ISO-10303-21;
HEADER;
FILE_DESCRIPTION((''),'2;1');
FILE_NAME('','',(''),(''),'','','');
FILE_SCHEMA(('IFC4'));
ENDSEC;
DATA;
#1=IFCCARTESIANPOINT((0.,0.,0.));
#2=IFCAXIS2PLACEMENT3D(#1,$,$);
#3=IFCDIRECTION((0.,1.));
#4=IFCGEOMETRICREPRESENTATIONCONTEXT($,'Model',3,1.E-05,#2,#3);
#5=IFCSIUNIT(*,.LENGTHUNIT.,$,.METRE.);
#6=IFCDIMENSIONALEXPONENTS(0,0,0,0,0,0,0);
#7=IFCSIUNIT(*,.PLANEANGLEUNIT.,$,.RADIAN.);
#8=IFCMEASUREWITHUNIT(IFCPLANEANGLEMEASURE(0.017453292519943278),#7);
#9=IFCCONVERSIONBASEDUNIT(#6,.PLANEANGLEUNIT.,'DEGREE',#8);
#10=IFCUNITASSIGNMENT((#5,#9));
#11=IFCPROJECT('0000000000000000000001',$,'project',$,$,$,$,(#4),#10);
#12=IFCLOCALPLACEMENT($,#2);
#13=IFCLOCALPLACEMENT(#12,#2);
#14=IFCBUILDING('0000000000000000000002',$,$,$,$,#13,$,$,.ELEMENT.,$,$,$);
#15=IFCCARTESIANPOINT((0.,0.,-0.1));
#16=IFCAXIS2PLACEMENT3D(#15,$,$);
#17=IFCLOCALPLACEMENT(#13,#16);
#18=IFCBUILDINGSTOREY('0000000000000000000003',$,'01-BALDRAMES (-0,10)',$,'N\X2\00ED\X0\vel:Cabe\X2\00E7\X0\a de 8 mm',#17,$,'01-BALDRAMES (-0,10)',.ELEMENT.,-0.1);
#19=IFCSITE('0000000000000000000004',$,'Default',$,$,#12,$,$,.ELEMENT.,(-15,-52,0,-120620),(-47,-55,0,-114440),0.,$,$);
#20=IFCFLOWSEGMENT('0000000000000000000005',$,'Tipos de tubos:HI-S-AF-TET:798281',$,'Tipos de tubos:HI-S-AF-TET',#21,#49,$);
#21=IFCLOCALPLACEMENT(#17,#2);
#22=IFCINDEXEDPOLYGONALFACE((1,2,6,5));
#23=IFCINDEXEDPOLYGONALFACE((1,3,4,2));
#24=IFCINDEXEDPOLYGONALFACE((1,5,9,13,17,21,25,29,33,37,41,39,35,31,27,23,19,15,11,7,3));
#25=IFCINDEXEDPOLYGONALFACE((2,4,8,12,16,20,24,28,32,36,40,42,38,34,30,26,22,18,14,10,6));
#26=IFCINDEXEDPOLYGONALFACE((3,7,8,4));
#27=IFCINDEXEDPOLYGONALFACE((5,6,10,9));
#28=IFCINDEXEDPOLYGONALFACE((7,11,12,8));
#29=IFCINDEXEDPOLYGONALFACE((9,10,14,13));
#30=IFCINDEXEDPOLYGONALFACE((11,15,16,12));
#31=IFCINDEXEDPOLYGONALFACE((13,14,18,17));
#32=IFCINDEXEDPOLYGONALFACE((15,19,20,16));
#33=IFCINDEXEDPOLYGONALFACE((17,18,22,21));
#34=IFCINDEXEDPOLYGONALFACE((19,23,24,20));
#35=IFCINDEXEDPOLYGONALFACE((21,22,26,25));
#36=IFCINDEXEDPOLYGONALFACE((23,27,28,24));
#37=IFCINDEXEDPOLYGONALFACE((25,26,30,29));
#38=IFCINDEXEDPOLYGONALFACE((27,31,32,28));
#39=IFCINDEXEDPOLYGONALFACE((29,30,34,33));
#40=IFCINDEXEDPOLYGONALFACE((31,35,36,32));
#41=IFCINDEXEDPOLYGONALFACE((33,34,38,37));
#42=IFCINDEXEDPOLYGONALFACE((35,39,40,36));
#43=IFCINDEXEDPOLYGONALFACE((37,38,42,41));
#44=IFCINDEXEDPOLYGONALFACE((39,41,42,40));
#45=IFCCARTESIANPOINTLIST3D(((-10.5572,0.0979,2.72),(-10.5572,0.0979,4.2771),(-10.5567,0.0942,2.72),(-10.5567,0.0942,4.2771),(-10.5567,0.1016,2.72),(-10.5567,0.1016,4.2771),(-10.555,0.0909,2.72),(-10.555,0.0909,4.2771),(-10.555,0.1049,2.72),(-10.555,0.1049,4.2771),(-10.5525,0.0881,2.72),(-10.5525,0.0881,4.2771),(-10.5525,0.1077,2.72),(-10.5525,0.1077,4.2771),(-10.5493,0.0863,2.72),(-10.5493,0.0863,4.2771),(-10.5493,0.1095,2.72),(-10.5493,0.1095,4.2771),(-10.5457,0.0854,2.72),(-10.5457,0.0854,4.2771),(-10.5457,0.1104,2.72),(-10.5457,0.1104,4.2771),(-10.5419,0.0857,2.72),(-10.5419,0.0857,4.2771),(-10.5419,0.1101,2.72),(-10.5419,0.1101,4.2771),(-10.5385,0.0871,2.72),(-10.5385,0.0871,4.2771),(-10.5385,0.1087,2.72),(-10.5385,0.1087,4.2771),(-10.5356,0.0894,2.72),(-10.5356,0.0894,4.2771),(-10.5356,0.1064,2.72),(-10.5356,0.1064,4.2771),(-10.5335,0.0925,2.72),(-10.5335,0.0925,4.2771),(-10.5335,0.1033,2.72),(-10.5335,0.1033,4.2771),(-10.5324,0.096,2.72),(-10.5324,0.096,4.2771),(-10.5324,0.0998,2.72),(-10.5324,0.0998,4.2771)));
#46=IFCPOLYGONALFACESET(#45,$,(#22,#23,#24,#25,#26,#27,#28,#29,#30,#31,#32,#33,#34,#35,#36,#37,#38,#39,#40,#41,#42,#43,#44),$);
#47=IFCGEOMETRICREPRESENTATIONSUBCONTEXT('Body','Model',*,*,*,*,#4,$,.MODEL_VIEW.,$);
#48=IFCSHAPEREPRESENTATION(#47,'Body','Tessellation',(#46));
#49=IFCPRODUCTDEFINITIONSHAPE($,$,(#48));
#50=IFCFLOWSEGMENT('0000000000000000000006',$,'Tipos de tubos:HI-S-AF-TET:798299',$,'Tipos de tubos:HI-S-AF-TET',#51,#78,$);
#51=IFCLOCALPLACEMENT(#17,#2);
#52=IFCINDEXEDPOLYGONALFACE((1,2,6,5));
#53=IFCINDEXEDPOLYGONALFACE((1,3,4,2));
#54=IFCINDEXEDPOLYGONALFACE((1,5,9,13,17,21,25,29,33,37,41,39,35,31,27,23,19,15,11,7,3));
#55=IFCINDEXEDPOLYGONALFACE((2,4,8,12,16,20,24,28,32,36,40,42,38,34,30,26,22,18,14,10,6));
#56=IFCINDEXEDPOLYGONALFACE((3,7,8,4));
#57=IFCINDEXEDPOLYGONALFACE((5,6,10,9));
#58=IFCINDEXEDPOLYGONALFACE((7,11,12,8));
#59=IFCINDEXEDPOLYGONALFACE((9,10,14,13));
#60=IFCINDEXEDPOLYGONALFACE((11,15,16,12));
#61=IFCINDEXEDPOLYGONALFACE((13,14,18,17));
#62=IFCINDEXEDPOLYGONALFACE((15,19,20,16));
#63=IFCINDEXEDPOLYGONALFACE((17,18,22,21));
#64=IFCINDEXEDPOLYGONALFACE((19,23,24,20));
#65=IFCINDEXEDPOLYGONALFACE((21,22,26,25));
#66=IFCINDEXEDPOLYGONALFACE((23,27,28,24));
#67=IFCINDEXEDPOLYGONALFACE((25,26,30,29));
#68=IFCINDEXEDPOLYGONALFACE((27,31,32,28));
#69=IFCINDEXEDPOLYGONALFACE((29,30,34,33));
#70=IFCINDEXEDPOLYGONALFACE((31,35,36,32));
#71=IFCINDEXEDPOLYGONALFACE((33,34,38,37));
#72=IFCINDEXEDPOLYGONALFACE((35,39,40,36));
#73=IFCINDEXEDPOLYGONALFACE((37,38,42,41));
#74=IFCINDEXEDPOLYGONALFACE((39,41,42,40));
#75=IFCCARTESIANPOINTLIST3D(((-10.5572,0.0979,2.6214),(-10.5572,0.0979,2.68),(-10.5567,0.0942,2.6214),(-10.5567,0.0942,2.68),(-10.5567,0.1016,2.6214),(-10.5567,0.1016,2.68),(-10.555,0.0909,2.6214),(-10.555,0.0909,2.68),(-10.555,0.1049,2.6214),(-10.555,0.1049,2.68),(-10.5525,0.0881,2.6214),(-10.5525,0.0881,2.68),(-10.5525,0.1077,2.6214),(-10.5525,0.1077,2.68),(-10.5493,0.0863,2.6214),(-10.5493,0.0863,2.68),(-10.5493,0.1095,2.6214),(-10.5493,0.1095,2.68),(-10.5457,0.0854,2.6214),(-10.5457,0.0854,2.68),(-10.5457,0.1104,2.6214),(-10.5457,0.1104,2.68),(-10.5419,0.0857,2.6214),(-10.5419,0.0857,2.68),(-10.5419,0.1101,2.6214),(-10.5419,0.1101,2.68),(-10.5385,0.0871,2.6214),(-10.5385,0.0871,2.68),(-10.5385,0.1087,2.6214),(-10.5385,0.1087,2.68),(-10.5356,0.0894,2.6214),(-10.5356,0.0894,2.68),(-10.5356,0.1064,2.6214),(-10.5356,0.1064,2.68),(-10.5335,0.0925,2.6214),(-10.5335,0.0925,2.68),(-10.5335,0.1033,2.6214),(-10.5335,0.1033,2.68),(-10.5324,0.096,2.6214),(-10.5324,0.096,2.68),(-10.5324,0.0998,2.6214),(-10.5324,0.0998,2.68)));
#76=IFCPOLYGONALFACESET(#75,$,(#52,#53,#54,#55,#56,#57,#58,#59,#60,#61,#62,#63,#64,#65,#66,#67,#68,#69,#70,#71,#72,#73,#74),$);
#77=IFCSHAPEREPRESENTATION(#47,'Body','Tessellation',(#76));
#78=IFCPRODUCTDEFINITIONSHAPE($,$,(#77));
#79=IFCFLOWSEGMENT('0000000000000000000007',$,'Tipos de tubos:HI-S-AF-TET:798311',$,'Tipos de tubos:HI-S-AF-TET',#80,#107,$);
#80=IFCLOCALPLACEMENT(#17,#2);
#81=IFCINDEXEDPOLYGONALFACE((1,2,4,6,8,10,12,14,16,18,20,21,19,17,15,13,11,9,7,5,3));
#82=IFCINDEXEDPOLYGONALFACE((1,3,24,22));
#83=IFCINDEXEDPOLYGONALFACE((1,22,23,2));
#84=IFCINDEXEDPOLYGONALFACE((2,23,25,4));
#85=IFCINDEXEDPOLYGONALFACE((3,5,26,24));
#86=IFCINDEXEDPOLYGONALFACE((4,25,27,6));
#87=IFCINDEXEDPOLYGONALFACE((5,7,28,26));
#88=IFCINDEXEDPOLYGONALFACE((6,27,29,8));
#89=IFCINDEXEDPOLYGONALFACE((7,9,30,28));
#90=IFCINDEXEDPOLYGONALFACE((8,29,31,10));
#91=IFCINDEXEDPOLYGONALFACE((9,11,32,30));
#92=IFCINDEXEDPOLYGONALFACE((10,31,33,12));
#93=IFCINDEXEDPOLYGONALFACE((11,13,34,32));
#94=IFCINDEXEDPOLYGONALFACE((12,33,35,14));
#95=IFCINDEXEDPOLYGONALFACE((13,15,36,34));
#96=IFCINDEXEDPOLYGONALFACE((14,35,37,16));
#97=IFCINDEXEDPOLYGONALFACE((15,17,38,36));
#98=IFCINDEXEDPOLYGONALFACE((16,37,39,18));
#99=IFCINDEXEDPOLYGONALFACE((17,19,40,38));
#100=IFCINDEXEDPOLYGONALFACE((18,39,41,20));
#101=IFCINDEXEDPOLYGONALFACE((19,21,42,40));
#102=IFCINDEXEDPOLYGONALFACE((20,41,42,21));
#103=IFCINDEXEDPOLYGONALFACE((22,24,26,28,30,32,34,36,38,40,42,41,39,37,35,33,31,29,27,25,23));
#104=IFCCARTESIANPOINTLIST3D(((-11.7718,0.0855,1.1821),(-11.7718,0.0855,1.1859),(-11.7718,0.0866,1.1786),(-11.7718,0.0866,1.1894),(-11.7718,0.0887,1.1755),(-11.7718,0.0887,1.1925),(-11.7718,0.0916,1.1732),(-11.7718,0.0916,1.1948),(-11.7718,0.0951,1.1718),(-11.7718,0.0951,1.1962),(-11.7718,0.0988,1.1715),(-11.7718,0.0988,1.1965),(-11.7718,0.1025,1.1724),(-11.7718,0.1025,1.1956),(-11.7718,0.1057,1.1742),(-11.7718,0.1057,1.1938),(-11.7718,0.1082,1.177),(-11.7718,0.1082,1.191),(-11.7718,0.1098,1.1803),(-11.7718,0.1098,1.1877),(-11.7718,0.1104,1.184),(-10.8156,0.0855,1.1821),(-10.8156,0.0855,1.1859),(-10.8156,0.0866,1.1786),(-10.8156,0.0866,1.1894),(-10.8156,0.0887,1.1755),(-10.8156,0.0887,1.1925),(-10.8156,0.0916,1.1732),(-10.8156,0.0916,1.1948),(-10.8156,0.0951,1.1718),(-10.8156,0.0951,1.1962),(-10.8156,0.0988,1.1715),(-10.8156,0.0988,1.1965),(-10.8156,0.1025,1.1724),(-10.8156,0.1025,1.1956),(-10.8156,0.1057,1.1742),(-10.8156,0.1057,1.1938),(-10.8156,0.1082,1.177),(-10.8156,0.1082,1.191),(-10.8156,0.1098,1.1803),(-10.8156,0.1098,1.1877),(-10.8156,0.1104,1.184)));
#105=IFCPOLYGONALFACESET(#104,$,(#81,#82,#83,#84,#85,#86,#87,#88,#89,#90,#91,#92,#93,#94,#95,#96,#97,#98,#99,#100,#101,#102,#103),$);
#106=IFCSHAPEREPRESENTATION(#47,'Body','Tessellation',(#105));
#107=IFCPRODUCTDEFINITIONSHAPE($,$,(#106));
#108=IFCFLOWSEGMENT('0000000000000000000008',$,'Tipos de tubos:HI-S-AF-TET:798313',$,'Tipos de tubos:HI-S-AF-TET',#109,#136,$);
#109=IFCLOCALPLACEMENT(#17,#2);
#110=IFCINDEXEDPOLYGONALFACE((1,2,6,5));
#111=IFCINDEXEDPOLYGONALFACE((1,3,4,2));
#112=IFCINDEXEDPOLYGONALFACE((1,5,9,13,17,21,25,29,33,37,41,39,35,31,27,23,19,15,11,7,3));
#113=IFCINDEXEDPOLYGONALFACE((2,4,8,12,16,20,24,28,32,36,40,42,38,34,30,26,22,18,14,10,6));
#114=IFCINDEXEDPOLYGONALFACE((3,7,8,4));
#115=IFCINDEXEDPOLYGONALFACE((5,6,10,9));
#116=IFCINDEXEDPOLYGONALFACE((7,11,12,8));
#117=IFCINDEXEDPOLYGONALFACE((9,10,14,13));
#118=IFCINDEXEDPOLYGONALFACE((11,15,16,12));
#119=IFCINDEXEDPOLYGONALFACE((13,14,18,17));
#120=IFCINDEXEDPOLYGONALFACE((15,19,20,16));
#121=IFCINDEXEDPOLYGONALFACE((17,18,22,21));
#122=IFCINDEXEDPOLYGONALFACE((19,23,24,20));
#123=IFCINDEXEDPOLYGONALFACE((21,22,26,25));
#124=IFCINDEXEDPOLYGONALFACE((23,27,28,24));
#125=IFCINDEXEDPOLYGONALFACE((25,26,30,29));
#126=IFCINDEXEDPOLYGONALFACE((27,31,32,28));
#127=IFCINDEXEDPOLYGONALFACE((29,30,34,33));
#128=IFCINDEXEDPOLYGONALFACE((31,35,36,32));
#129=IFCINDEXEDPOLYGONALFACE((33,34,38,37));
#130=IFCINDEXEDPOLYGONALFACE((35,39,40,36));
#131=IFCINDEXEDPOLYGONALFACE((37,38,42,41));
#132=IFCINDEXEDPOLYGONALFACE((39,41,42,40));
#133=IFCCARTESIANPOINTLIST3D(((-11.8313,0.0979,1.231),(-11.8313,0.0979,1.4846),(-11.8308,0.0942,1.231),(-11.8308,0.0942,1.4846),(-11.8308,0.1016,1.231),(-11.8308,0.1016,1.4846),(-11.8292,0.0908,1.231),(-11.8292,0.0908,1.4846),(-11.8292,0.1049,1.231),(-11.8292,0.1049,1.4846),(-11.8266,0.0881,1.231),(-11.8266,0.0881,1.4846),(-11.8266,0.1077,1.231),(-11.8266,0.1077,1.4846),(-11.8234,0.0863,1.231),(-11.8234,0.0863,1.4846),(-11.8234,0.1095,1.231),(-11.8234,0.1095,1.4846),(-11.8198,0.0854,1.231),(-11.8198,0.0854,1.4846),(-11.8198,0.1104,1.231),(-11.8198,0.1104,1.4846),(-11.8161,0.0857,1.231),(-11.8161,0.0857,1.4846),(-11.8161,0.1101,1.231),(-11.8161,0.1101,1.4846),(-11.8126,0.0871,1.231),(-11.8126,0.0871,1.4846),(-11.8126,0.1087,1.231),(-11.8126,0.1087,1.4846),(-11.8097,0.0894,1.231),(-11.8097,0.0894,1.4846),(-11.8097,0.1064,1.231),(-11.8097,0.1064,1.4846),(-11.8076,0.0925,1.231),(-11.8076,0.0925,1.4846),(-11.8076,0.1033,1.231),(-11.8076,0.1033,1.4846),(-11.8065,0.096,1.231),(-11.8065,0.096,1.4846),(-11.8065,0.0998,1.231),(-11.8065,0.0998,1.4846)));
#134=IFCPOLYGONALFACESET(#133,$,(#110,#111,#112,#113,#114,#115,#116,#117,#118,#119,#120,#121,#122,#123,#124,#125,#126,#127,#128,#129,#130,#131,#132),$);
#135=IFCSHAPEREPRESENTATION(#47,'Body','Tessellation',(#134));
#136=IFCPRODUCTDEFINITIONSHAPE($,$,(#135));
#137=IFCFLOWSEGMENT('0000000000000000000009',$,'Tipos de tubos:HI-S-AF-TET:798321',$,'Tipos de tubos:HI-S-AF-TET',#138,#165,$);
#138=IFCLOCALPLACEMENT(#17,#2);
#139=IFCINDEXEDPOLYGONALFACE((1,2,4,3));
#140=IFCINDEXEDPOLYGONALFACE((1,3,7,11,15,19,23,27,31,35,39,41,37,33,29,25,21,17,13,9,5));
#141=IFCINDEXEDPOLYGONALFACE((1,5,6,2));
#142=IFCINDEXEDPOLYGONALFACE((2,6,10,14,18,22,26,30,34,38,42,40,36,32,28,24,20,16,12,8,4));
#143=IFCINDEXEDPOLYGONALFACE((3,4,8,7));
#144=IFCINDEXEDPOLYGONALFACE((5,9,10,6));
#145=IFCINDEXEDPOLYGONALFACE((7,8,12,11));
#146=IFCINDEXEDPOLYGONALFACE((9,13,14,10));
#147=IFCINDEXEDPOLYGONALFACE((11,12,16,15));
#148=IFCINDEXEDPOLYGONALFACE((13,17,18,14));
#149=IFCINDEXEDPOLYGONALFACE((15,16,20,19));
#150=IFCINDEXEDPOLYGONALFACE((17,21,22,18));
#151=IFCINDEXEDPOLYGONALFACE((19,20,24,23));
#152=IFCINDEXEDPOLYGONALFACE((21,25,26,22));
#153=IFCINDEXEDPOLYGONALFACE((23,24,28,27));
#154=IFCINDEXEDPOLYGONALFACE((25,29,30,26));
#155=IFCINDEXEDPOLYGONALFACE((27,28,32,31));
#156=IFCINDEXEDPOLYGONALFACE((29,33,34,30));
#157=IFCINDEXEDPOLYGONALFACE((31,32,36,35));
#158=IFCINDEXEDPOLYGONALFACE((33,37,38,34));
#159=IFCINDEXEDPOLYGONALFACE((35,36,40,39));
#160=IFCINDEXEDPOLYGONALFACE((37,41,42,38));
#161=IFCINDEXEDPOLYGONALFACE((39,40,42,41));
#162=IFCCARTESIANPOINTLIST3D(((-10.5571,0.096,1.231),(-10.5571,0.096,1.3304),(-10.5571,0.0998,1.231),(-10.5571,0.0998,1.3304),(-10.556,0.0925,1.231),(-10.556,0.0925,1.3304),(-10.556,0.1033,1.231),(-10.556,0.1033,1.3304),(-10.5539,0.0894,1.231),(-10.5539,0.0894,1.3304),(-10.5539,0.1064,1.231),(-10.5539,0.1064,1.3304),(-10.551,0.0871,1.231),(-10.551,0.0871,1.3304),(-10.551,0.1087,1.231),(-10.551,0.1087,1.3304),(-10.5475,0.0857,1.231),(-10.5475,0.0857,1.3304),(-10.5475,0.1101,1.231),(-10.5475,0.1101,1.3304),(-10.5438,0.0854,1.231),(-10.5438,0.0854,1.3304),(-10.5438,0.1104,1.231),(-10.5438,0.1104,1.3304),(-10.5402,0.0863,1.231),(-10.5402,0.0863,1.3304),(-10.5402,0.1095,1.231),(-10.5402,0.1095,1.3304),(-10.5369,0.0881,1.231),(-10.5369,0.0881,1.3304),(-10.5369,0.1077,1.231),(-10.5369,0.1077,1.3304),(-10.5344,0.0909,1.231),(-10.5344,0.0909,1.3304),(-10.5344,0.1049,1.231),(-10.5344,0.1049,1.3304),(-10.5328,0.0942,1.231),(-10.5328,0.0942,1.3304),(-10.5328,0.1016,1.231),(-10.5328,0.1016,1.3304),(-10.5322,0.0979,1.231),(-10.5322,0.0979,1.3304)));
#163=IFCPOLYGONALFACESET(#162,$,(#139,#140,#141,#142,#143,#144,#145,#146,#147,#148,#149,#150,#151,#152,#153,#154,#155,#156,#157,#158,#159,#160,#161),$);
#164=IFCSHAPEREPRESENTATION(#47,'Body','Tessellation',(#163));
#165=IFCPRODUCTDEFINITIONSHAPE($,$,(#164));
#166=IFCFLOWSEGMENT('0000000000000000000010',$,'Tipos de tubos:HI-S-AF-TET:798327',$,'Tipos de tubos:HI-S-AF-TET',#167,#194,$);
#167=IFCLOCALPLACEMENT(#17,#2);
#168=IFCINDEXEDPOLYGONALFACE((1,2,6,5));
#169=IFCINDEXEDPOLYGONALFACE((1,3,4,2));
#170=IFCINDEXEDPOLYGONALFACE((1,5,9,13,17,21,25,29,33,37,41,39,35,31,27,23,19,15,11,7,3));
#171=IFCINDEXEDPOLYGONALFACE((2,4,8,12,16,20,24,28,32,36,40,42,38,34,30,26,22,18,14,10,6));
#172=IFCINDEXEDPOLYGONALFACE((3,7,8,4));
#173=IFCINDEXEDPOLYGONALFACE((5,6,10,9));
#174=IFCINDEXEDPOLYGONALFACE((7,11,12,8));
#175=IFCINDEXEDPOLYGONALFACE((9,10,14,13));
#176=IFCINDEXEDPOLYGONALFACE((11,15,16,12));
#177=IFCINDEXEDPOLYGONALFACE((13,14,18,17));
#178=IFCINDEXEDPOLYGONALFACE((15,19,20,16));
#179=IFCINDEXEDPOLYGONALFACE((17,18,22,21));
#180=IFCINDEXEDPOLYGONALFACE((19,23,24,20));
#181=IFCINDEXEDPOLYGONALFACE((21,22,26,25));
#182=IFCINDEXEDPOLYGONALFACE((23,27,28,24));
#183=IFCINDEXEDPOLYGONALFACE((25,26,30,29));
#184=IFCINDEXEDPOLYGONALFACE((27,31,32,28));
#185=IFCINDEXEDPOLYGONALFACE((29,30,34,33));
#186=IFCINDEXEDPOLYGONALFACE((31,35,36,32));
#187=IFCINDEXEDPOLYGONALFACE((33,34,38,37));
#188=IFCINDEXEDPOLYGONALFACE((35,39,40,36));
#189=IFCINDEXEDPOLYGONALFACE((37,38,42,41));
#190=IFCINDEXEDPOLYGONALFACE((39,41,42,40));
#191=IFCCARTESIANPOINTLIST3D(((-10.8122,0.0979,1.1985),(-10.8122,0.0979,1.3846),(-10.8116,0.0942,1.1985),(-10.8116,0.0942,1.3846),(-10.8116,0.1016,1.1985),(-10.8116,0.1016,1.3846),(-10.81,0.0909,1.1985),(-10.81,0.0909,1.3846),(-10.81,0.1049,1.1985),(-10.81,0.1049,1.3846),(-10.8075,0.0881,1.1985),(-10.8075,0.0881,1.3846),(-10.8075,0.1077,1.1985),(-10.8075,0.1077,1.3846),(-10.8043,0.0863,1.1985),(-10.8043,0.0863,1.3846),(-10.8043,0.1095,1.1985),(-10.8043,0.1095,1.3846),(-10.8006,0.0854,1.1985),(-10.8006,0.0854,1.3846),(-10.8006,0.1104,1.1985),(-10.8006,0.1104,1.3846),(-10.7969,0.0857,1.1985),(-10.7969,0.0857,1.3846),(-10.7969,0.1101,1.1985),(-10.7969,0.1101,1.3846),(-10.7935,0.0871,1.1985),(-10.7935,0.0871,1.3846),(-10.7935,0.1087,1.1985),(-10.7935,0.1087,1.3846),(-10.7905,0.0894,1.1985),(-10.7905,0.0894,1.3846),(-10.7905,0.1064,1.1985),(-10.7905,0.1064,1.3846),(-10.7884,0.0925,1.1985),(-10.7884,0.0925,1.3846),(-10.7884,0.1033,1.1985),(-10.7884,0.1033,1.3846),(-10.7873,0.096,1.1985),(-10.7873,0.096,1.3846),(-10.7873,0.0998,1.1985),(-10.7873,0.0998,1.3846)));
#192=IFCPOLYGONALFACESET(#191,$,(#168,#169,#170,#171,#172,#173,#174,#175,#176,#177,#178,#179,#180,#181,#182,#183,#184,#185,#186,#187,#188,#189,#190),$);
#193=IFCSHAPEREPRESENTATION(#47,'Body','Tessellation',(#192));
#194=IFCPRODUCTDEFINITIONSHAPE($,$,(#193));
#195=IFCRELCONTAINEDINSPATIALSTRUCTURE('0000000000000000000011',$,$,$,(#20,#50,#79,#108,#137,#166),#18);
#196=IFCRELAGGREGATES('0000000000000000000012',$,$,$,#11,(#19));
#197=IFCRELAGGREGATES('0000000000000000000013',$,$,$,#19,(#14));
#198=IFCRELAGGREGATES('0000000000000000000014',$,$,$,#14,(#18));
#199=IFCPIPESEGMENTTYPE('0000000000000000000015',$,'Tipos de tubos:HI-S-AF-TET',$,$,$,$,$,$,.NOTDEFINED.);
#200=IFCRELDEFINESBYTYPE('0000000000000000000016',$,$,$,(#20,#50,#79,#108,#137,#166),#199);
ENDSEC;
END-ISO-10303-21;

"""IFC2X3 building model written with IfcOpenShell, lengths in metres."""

from ifc_helpers import new_model, entity, si_unit, converted_unit, direction, frame, frame_2d, origin, origin_2d_with_axis, place, context, subcontext, project, spatial, circle, extrude, type_object, element, save


model = new_model("IFC2X3")

# Units and contexts
model_context = context("Model", 3, precision=1e-05, world=origin(), true_north=direction((0.0, 1.0)))
body_context = subcontext(model_context, "Body", "Model", "MODEL_VIEW")
ifc_project = project(units=[si_unit("LENGTHUNIT", "METRE"), converted_unit("PLANEANGLEUNIT", "DEGREE", entity("IfcPlaneAngleMeasure", 0.017453292519943278), si_unit("PLANEANGLEUNIT", "RADIAN"), dimensions=[0, 0, 0, 0, 0, 0, 0])], contexts=[model_context])

# Site, building, storey
site_placement = place(None, origin())
site = spatial("IfcSite", under=ifc_project, at=site_placement, Name="Default", CompositionType="ELEMENT", RefLatitude=(-15, -52, 0, -120620), RefLongitude=(-47, -55, 0, -114440), RefElevation=0.0)
building_placement = place(site_placement, origin())
building = spatial("IfcBuilding", under=site, at=building_placement, CompositionType="ELEMENT")
storey_placement = place(building_placement, frame((0.0, 0.0, -0.1)))
storey = spatial("IfcBuildingStorey", under=building, at=storey_placement, Name="01-BALDRAMES (-0,10)", ObjectType="Nível:Cabeça de 8 mm", LongName="01-BALDRAMES (-0,10)", CompositionType="ELEMENT", Elevation=-0.1)

# Flow segments
pipe_segment_type_1 = type_object("IfcPipeSegmentType", Name="Tipos de tubos:HI-S-AF-TET", PredefinedType="NOTDEFINED")
flow_segment_1_placement = place(storey_placement, origin())
element("IfcFlowSegment", 1, at=flow_segment_1_placement, inside=storey, type_object=pipe_segment_type_1, Name="Tipos de tubos:HI-S-AF-TET:798281", ObjectType="Tipos de tubos:HI-S-AF-TET", context=body_context, shape_type="SweptSolid", body=[
    extrude(circle(Radius=0.0125, at=origin_2d_with_axis()), frame((-10.5447, 0.0979, 2.72), z_axis=(0.0, 0.0, 1.0), x_axis=(-1.0, 0.0, 0.0)), (0.0, 0.0, 1.0), 1.5571),
])
flow_segment_2_placement = place(storey_placement, origin())
element("IfcFlowSegment", 2, at=flow_segment_2_placement, inside=storey, type_object=pipe_segment_type_1, Name="Tipos de tubos:HI-S-AF-TET:798299", ObjectType="Tipos de tubos:HI-S-AF-TET", context=body_context, shape_type="SweptSolid", body=[
    extrude(circle(Radius=0.0125, at=origin_2d_with_axis()), frame((-10.5447, 0.0979, 2.6214), z_axis=(0.0, 0.0, 1.0), x_axis=(-1.0, 0.0, 0.0)), (0.0, 0.0, 1.0), 0.0586),
])
flow_segment_3_placement = place(storey_placement, origin())
element("IfcFlowSegment", 3, at=flow_segment_3_placement, inside=storey, type_object=pipe_segment_type_1, Name="Tipos de tubos:HI-S-AF-TET:798311", ObjectType="Tipos de tubos:HI-S-AF-TET", context=body_context, shape_type="SweptSolid", body=[
    extrude(circle(Radius=0.0125, at=frame_2d((0.0, 0.0), x_axis=(1.0, 0.0))), frame((-11.7718, 0.0979, 1.184), z_axis=(1.0, 0.000004, 0.0), x_axis=(-0.000004, 1.0, 0.0)), (0.0, 0.0, 1.0), 0.9562),
])
flow_segment_4_placement = place(storey_placement, origin())
element("IfcFlowSegment", 4, at=flow_segment_4_placement, inside=storey, type_object=pipe_segment_type_1, Name="Tipos de tubos:HI-S-AF-TET:798313", ObjectType="Tipos de tubos:HI-S-AF-TET", context=body_context, shape_type="SweptSolid", body=[
    extrude(circle(Radius=0.0125, at=frame_2d((0.0, 0.0), x_axis=(1.0, 0.0))), frame((-11.8188, 0.0979, 1.231), z_axis=(0.0, 0.0, 1.0), x_axis=(-1.0, 0.0, 0.0)), (0.0, 0.0, 1.0), 0.2536),
])
flow_segment_5_placement = place(storey_placement, origin())
element("IfcFlowSegment", 5, at=flow_segment_5_placement, inside=storey, type_object=pipe_segment_type_1, Name="Tipos de tubos:HI-S-AF-TET:798321", ObjectType="Tipos de tubos:HI-S-AF-TET", context=body_context, shape_type="SweptSolid", body=[
    extrude(circle(Radius=0.0125, at=frame_2d((0.0, 0.0), x_axis=(1.0, 0.0))), frame((-10.5447, 0.0979, 1.231)), (0.0, 0.0, 1.0), 0.0994),
])
flow_segment_6_placement = place(storey_placement, origin())
element("IfcFlowSegment", 6, at=flow_segment_6_placement, inside=storey, type_object=pipe_segment_type_1, Name="Tipos de tubos:HI-S-AF-TET:798327", ObjectType="Tipos de tubos:HI-S-AF-TET", context=body_context, shape_type="SweptSolid", body=[
    extrude(circle(Radius=0.0125, at=origin_2d_with_axis()), frame((-10.7997, 0.0979, 1.1985), z_axis=(0.0, 0.0, 1.0), x_axis=(-1.0, 0.0, 0.0)), (0.0, 0.0, 1.0), 0.1861),
])

save(model, "model.ifc")
